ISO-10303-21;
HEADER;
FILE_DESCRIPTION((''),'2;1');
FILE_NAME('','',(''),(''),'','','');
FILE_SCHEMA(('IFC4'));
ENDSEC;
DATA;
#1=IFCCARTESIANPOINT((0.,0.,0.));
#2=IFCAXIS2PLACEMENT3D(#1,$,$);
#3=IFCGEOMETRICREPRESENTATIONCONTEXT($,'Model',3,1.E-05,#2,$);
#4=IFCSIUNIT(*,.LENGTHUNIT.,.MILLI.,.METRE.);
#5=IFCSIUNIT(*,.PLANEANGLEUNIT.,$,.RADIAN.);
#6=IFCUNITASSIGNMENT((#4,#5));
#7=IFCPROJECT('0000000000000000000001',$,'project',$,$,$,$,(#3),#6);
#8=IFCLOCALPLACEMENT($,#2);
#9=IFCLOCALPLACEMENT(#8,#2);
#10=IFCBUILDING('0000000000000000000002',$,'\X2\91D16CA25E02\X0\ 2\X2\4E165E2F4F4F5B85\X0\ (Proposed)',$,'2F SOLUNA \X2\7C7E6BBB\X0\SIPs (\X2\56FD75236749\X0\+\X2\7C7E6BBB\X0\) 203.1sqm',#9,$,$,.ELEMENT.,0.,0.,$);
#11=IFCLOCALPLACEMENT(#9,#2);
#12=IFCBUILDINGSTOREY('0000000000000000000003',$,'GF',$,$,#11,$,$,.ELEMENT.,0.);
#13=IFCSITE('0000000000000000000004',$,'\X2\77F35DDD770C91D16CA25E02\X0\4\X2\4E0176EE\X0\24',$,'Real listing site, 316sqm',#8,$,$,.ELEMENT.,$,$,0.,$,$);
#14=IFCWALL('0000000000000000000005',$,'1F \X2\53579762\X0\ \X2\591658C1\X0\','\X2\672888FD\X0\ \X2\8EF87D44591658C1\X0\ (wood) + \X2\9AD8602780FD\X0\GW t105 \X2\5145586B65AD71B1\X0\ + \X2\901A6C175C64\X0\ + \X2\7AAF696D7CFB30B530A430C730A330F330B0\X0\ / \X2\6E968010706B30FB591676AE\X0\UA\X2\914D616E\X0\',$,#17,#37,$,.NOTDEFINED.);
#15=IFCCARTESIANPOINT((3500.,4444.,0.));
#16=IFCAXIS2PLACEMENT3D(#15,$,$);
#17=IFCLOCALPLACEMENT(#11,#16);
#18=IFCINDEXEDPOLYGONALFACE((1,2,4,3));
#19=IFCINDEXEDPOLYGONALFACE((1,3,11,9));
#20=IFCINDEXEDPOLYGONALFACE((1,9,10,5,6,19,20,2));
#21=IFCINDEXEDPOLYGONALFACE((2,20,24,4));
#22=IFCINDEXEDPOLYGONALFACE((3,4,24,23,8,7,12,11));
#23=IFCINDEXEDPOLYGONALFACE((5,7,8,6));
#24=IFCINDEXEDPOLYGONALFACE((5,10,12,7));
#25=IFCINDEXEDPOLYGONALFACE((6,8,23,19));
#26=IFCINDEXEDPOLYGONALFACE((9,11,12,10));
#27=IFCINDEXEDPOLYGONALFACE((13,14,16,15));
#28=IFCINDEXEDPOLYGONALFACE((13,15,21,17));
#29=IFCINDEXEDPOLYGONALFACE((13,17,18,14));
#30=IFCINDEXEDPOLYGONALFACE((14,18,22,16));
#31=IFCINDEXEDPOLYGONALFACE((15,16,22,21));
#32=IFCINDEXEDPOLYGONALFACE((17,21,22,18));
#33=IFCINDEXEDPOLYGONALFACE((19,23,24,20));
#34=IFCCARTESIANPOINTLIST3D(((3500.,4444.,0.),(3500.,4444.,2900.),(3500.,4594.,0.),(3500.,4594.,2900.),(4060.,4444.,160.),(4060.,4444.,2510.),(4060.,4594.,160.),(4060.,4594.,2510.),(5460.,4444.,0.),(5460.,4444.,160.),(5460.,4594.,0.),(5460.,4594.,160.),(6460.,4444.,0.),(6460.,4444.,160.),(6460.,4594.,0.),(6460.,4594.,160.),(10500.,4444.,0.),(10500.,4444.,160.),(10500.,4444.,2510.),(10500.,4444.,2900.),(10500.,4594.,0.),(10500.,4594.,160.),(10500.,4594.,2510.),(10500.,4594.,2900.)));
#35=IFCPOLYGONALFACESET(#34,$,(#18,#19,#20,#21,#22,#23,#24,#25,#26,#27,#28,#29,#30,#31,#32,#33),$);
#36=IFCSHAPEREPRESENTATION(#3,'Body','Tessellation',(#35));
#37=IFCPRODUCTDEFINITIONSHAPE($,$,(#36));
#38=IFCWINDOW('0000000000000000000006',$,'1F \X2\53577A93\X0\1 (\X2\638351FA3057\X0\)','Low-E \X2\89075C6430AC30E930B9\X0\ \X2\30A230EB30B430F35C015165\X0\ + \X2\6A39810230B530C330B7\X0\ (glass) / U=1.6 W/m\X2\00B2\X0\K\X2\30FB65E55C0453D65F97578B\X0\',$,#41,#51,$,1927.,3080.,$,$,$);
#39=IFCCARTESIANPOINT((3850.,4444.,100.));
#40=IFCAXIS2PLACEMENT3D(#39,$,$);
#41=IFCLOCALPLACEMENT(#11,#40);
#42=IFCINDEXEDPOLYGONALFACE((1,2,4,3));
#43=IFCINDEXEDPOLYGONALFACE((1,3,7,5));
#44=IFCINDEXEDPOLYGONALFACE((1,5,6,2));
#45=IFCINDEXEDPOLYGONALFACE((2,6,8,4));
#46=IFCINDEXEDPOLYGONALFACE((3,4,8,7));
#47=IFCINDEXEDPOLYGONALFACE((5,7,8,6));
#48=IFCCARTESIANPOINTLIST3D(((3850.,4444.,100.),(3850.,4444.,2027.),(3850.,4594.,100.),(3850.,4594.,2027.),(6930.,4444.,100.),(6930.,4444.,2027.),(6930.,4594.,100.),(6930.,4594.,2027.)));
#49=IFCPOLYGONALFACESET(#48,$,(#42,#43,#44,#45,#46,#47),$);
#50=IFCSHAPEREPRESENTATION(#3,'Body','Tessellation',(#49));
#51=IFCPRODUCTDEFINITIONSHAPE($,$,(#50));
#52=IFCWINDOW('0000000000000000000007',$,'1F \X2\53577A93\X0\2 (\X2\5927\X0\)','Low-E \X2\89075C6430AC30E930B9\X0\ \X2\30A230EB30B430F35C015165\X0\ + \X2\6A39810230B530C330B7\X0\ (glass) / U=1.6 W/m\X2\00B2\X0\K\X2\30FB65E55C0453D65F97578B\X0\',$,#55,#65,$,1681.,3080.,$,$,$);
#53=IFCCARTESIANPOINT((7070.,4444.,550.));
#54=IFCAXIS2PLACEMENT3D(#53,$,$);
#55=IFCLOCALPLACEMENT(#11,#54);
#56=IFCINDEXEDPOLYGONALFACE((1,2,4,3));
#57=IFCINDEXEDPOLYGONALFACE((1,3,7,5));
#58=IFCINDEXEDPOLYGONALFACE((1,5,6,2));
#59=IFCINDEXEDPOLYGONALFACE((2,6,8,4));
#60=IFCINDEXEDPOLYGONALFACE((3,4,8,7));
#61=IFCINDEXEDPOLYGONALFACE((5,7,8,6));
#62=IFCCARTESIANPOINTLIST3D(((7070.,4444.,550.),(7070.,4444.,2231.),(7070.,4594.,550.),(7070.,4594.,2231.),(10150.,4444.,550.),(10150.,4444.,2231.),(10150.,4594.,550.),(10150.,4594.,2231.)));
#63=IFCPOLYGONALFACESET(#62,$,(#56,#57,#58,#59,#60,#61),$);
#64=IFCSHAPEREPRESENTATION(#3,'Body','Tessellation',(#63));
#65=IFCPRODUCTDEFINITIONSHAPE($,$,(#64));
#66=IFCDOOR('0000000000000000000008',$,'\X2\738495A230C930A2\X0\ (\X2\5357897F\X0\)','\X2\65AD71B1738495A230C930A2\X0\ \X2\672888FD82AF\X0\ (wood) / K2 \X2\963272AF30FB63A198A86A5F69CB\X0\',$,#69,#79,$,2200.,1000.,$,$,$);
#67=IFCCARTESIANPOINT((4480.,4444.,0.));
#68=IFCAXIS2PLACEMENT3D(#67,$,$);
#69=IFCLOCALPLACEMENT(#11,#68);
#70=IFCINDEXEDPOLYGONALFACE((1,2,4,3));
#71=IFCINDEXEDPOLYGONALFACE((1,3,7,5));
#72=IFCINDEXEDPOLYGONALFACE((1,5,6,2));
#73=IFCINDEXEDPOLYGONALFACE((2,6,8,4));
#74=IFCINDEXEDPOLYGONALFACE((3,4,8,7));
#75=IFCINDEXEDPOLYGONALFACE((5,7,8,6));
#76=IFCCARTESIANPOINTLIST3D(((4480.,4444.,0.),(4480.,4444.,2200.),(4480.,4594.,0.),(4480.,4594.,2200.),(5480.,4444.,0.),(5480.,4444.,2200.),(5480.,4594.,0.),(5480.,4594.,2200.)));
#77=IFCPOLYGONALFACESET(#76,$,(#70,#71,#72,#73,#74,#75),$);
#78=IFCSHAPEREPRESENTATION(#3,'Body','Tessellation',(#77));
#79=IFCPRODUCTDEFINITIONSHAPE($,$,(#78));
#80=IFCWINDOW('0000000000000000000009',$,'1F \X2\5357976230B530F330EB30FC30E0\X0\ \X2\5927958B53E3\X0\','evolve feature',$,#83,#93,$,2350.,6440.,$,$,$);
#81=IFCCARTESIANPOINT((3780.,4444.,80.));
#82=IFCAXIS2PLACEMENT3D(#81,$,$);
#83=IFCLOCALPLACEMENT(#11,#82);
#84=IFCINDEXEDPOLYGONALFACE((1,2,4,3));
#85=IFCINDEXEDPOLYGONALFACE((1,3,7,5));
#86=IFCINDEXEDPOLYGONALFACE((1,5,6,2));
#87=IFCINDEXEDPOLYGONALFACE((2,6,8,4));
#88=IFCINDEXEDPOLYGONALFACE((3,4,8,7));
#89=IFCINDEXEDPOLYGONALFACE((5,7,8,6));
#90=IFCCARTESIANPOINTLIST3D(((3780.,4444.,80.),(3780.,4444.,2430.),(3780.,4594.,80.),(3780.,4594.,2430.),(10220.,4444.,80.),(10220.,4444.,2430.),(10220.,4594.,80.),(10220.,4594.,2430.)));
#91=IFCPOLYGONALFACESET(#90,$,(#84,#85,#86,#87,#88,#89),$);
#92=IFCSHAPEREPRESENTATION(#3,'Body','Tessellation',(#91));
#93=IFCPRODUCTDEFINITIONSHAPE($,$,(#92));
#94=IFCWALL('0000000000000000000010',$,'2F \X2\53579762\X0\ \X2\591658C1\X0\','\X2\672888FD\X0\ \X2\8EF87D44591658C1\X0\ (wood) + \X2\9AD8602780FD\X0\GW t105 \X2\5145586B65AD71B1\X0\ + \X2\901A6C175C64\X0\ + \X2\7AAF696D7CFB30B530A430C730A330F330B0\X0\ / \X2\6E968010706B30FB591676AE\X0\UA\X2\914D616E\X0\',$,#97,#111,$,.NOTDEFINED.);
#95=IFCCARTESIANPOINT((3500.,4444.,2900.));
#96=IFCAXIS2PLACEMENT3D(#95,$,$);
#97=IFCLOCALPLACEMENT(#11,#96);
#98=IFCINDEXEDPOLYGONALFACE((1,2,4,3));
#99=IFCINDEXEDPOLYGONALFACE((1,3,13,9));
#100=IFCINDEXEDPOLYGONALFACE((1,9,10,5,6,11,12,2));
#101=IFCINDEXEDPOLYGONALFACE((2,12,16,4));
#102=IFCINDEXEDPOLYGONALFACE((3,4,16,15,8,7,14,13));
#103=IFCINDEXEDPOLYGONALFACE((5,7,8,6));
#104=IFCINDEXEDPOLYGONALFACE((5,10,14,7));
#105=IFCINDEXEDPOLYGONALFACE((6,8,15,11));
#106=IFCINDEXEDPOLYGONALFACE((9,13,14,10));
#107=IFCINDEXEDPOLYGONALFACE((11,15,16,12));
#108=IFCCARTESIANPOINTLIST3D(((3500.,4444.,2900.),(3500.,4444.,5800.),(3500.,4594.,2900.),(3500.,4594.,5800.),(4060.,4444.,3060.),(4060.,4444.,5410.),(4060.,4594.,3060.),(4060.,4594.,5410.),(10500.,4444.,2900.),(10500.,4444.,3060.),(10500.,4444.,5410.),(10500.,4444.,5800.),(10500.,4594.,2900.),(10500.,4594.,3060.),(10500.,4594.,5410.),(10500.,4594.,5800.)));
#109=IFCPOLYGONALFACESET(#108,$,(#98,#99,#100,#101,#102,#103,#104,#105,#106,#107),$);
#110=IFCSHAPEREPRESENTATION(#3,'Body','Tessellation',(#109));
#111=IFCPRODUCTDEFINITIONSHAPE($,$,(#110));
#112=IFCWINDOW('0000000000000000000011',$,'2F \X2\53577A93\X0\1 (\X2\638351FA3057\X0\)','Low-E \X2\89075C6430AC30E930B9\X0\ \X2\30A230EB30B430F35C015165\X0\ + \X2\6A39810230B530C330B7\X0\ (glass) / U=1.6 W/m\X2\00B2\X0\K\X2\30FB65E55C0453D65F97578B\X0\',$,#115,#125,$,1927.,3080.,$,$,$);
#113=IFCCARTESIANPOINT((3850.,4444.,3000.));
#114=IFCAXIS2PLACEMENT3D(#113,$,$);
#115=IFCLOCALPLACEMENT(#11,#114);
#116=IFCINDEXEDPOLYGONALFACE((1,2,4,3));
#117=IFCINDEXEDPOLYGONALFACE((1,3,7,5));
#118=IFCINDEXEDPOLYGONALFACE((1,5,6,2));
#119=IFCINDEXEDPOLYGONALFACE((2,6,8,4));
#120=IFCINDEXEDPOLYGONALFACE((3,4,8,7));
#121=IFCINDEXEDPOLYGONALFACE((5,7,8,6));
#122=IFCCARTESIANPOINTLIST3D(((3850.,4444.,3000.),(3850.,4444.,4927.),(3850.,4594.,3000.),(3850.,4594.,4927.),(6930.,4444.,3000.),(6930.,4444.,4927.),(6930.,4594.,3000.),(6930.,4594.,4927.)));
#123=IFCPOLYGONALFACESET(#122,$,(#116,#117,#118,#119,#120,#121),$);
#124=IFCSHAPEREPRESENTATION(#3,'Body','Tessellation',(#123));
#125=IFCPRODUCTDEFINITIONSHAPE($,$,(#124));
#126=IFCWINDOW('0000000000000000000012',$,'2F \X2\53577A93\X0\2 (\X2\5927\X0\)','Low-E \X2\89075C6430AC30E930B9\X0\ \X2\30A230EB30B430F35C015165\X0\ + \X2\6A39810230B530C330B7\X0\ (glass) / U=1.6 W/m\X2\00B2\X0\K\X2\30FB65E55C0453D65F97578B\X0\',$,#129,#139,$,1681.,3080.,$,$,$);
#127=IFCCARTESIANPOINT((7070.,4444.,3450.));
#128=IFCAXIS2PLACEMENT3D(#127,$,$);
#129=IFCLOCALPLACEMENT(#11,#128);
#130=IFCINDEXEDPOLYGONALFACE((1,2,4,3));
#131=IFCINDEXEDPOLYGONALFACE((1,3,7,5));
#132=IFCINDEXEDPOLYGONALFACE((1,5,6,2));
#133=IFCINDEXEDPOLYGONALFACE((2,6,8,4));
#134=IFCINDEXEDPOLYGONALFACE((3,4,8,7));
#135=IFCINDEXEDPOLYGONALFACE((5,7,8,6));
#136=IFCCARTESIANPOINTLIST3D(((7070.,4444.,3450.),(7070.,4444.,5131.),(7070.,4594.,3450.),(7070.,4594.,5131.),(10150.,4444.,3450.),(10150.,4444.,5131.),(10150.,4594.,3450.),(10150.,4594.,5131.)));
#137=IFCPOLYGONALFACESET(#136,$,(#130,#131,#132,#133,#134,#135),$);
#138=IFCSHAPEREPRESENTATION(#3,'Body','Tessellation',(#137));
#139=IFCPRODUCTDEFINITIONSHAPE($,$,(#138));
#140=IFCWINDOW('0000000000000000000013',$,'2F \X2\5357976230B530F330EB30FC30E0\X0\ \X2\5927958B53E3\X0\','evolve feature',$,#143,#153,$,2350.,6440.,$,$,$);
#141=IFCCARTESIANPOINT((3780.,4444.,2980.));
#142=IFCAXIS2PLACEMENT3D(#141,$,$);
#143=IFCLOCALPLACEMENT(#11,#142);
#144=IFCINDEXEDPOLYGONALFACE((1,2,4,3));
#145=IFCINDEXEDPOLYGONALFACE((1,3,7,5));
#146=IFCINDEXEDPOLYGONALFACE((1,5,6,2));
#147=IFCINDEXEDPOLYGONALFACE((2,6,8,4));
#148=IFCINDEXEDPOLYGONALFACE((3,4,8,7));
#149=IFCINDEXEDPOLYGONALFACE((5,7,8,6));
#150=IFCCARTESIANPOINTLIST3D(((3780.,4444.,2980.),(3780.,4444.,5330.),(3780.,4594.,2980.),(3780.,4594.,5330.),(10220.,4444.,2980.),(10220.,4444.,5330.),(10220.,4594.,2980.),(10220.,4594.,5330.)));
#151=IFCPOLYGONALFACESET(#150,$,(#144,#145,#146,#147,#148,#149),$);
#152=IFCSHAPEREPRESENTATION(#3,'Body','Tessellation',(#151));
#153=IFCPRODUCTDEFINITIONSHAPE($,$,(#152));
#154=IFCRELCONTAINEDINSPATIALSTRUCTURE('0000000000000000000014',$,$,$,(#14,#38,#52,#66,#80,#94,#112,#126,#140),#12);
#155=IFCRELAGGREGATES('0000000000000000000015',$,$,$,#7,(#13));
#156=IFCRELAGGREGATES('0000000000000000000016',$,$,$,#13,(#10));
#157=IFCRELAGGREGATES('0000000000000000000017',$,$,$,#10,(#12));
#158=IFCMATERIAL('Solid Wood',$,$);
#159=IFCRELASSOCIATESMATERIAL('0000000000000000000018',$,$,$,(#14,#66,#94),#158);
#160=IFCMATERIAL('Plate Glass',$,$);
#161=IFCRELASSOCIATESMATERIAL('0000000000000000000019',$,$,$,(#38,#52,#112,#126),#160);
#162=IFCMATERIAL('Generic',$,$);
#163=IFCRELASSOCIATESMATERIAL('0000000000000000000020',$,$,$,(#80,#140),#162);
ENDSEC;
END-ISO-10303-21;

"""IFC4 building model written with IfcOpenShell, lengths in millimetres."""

from ifc_helpers import new_model, si_unit, frame, frame_2d, origin, place, context, project, spatial, rectangle, extrude, material, element, fill, save


model = new_model("IFC4")

# Units and contexts
model_context = context("Model", 3, precision=1e-05, world=origin())
ifc_project = project(units=[si_unit("LENGTHUNIT", "METRE", prefix="MILLI"), si_unit("PLANEANGLEUNIT", "RADIAN")], contexts=[model_context])

# Site, building, storey
site_placement = place(None, origin())
site = spatial("IfcSite", under=ifc_project, at=site_placement, Name="石川県金沢市4丁目24", ObjectType="Real listing site, 316sqm", CompositionType="ELEMENT", RefElevation=0.0)
building_placement = place(site_placement, origin())
building = spatial("IfcBuilding", under=site, at=building_placement, Name="金沢市 2世帯住宅 (Proposed)", ObjectType="2F SOLUNA 籾殻SIPs (国産杉+籾殻) 203.1sqm", CompositionType="ELEMENT", ElevationOfRefHeight=0.0, ElevationOfTerrain=0.0)
storey_placement = place(building_placement, origin())
storey = spatial("IfcBuildingStorey", under=building, at=storey_placement, Name="GF", CompositionType="ELEMENT", Elevation=0.0)

# Shared definitions
ifc_material_1 = material(Name="Solid Wood")

# Wall, openings, windows, door
wall_1_placement = place(storey_placement, frame((3500.0, 4444.0, 0.0)))
wall_1 = element("IfcWall", 1, at=wall_1_placement, inside=storey, material=ifc_material_1, Name="1F 南面 外壁", Description="木製 軸組外壁 (wood) + 高性能GW t105 充填断熱 + 通気層 + 窯業系サイディング / 準耐火・外皮UA配慮", PredefinedType="NOTDEFINED", context=model_context, shape_type="SweptSolid", body=[
    extrude(rectangle(XDim=7000.0, YDim=150.0, at=frame_2d((3500.0, 75.0))), frame((3500.0, 4444.0, 0.0)), (0.0, 0.0, 1.0), 2900.0),
])
opening_1_placement = place(storey_placement, frame((3850.0, 4444.0, 100.0)))
opening_1 = element("IfcOpeningElement", 2, at=opening_1_placement, cuts=wall_1, PredefinedType="NOTDEFINED", context=model_context, shape_type="SweptSolid", body=[
    extrude(rectangle(XDim=3080.0, YDim=150.0, at=frame_2d((1540.0, 75.0))), frame((3850.0, 4444.0, 100.0)), (0.0, 0.0, 1.0), 1927.0),
])
opening_2_placement = place(storey_placement, frame((7070.0, 4444.0, 550.0)))
opening_2 = element("IfcOpeningElement", 3, at=opening_2_placement, cuts=wall_1, PredefinedType="NOTDEFINED", context=model_context, shape_type="SweptSolid", body=[
    extrude(rectangle(XDim=3080.0, YDim=150.0, at=frame_2d((1540.0, 75.0))), frame((7070.0, 4444.0, 550.0)), (0.0, 0.0, 1.0), 1681.0),
])
opening_3_placement = place(storey_placement, frame((4480.0, 4444.0, 0.0)))
opening_3 = element("IfcOpeningElement", 4, at=opening_3_placement, cuts=wall_1, PredefinedType="NOTDEFINED", context=model_context, shape_type="SweptSolid", body=[
    extrude(rectangle(XDim=1000.0, YDim=150.0, at=frame_2d((500.0, 75.0))), frame((4480.0, 4444.0, 0.0)), (0.0, 0.0, 1.0), 2200.0),
])
opening_4_placement = place(storey_placement, frame((3780.0, 4444.0, 80.0)))
opening_4 = element("IfcOpeningElement", 5, at=opening_4_placement, cuts=wall_1, PredefinedType="NOTDEFINED", context=model_context, shape_type="SweptSolid", body=[
    extrude(rectangle(XDim=6440.0, YDim=150.0, at=frame_2d((3220.0, 75.0))), frame((3780.0, 4444.0, 80.0)), (0.0, 0.0, 1.0), 2350.0),
])
ifc_material_2 = material(Name="Plate Glass")
window_1_placement = place(storey_placement, frame((3850.0, 4444.0, 100.0)))
window_1 = element("IfcWindow", 6, at=window_1_placement, inside=storey, material=ifc_material_2, Name="1F 南窓1 (掃出し)", Description="Low-E 複層ガラス アルゴン封入 + 樹脂サッシ (glass) / U=1.6 W/m²K・日射取得型", OverallHeight=1927.0, OverallWidth=3080.0, context=model_context, shape_type="SweptSolid", body=[
    extrude(rectangle(XDim=3080.0, YDim=150.0, at=frame_2d((1540.0, 75.0))), frame((3850.0, 4444.0, 100.0)), (0.0, 0.0, 1.0), 1927.0),
])
fill(opening_1, window_1)
window_2_placement = place(storey_placement, frame((7070.0, 4444.0, 550.0)))
window_2 = element("IfcWindow", 7, at=window_2_placement, inside=storey, material=ifc_material_2, Name="1F 南窓2 (大)", Description="Low-E 複層ガラス アルゴン封入 + 樹脂サッシ (glass) / U=1.6 W/m²K・日射取得型", OverallHeight=1681.0, OverallWidth=3080.0, context=model_context, shape_type="SweptSolid", body=[
    extrude(rectangle(XDim=3080.0, YDim=150.0, at=frame_2d((1540.0, 75.0))), frame((7070.0, 4444.0, 550.0)), (0.0, 0.0, 1.0), 1681.0),
])
fill(opening_2, window_2)
door_placement = place(storey_placement, frame((4480.0, 4444.0, 0.0)))
door = element("IfcDoor", 8, at=door_placement, inside=storey, material=ifc_material_1, Name="玄関ドア (南西)", Description="断熱玄関ドア 木製芯 (wood) / K2 防犯・採風機構", OverallHeight=2200.0, OverallWidth=1000.0, context=model_context, shape_type="SweptSolid", body=[
    extrude(rectangle(XDim=1000.0, YDim=150.0, at=frame_2d((500.0, 75.0))), frame((4480.0, 4444.0, 0.0)), (0.0, 0.0, 1.0), 2200.0),
])
fill(opening_3, door)
ifc_material_3 = material(Name="Generic")
window_3_placement = place(storey_placement, frame((3780.0, 4444.0, 80.0)))
window_3 = element("IfcWindow", 9, at=window_3_placement, inside=storey, material=ifc_material_3, Name="1F 南面サンルーム 大開口", Description="evolve feature", OverallHeight=2350.0, OverallWidth=6440.0, context=model_context, shape_type="SweptSolid", body=[
    extrude(rectangle(XDim=6440.0, YDim=150.0, at=frame_2d((3220.0, 75.0))), frame((3780.0, 4444.0, 80.0)), (0.0, 0.0, 1.0), 2350.0),
])
fill(opening_4, window_3)

# Wall, openings, windows
wall_2_placement = place(storey_placement, frame((3500.0, 4444.0, 2900.0)))
wall_2 = element("IfcWall", 10, at=wall_2_placement, inside=storey, material=ifc_material_1, Name="2F 南面 外壁", Description="木製 軸組外壁 (wood) + 高性能GW t105 充填断熱 + 通気層 + 窯業系サイディング / 準耐火・外皮UA配慮", PredefinedType="NOTDEFINED", context=model_context, shape_type="SweptSolid", body=[
    extrude(rectangle(XDim=7000.0, YDim=150.0, at=frame_2d((3500.0, 75.0))), frame((3500.0, 4444.0, 2900.0)), (0.0, 0.0, 1.0), 2900.0),
])
opening_5_placement = place(storey_placement, frame((3850.0, 4444.0, 3000.0)))
opening_5 = element("IfcOpeningElement", 11, at=opening_5_placement, cuts=wall_2, PredefinedType="NOTDEFINED", context=model_context, shape_type="SweptSolid", body=[
    extrude(rectangle(XDim=3080.0, YDim=150.0, at=frame_2d((1540.0, 75.0))), frame((3850.0, 4444.0, 3000.0)), (0.0, 0.0, 1.0), 1927.0),
])
opening_6_placement = place(storey_placement, frame((7070.0, 4444.0, 3450.0)))
opening_6 = element("IfcOpeningElement", 12, at=opening_6_placement, cuts=wall_2, PredefinedType="NOTDEFINED", context=model_context, shape_type="SweptSolid", body=[
    extrude(rectangle(XDim=3080.0, YDim=150.0, at=frame_2d((1540.0, 75.0))), frame((7070.0, 4444.0, 3450.0)), (0.0, 0.0, 1.0), 1681.0),
])
opening_7_placement = place(storey_placement, frame((3780.0, 4444.0, 2980.0)))
opening_7 = element("IfcOpeningElement", 13, at=opening_7_placement, cuts=wall_2, PredefinedType="NOTDEFINED", context=model_context, shape_type="SweptSolid", body=[
    extrude(rectangle(XDim=6440.0, YDim=150.0, at=frame_2d((3220.0, 75.0))), frame((3780.0, 4444.0, 2980.0)), (0.0, 0.0, 1.0), 2350.0),
])
window_4_placement = place(storey_placement, frame((3850.0, 4444.0, 3000.0)))
window_4 = element("IfcWindow", 14, at=window_4_placement, inside=storey, material=ifc_material_2, Name="2F 南窓1 (掃出し)", Description="Low-E 複層ガラス アルゴン封入 + 樹脂サッシ (glass) / U=1.6 W/m²K・日射取得型", OverallHeight=1927.0, OverallWidth=3080.0, context=model_context, shape_type="SweptSolid", body=[
    extrude(rectangle(XDim=3080.0, YDim=150.0, at=frame_2d((1540.0, 75.0))), frame((3850.0, 4444.0, 3000.0)), (0.0, 0.0, 1.0), 1927.0),
])
fill(opening_5, window_4)
window_5_placement = place(storey_placement, frame((7070.0, 4444.0, 3450.0)))
window_5 = element("IfcWindow", 15, at=window_5_placement, inside=storey, material=ifc_material_2, Name="2F 南窓2 (大)", Description="Low-E 複層ガラス アルゴン封入 + 樹脂サッシ (glass) / U=1.6 W/m²K・日射取得型", OverallHeight=1681.0, OverallWidth=3080.0, context=model_context, shape_type="SweptSolid", body=[
    extrude(rectangle(XDim=3080.0, YDim=150.0, at=frame_2d((1540.0, 75.0))), frame((7070.0, 4444.0, 3450.0)), (0.0, 0.0, 1.0), 1681.0),
])
fill(opening_6, window_5)
window_6_placement = place(storey_placement, frame((3780.0, 4444.0, 2980.0)))
window_6 = element("IfcWindow", 16, at=window_6_placement, inside=storey, material=ifc_material_3, Name="2F 南面サンルーム 大開口", Description="evolve feature", OverallHeight=2350.0, OverallWidth=6440.0, context=model_context, shape_type="SweptSolid", body=[
    extrude(rectangle(XDim=6440.0, YDim=150.0, at=frame_2d((3220.0, 75.0))), frame((3780.0, 4444.0, 2980.0)), (0.0, 0.0, 1.0), 2350.0),
])
fill(opening_7, window_6)

save(model, "model.ifc")
